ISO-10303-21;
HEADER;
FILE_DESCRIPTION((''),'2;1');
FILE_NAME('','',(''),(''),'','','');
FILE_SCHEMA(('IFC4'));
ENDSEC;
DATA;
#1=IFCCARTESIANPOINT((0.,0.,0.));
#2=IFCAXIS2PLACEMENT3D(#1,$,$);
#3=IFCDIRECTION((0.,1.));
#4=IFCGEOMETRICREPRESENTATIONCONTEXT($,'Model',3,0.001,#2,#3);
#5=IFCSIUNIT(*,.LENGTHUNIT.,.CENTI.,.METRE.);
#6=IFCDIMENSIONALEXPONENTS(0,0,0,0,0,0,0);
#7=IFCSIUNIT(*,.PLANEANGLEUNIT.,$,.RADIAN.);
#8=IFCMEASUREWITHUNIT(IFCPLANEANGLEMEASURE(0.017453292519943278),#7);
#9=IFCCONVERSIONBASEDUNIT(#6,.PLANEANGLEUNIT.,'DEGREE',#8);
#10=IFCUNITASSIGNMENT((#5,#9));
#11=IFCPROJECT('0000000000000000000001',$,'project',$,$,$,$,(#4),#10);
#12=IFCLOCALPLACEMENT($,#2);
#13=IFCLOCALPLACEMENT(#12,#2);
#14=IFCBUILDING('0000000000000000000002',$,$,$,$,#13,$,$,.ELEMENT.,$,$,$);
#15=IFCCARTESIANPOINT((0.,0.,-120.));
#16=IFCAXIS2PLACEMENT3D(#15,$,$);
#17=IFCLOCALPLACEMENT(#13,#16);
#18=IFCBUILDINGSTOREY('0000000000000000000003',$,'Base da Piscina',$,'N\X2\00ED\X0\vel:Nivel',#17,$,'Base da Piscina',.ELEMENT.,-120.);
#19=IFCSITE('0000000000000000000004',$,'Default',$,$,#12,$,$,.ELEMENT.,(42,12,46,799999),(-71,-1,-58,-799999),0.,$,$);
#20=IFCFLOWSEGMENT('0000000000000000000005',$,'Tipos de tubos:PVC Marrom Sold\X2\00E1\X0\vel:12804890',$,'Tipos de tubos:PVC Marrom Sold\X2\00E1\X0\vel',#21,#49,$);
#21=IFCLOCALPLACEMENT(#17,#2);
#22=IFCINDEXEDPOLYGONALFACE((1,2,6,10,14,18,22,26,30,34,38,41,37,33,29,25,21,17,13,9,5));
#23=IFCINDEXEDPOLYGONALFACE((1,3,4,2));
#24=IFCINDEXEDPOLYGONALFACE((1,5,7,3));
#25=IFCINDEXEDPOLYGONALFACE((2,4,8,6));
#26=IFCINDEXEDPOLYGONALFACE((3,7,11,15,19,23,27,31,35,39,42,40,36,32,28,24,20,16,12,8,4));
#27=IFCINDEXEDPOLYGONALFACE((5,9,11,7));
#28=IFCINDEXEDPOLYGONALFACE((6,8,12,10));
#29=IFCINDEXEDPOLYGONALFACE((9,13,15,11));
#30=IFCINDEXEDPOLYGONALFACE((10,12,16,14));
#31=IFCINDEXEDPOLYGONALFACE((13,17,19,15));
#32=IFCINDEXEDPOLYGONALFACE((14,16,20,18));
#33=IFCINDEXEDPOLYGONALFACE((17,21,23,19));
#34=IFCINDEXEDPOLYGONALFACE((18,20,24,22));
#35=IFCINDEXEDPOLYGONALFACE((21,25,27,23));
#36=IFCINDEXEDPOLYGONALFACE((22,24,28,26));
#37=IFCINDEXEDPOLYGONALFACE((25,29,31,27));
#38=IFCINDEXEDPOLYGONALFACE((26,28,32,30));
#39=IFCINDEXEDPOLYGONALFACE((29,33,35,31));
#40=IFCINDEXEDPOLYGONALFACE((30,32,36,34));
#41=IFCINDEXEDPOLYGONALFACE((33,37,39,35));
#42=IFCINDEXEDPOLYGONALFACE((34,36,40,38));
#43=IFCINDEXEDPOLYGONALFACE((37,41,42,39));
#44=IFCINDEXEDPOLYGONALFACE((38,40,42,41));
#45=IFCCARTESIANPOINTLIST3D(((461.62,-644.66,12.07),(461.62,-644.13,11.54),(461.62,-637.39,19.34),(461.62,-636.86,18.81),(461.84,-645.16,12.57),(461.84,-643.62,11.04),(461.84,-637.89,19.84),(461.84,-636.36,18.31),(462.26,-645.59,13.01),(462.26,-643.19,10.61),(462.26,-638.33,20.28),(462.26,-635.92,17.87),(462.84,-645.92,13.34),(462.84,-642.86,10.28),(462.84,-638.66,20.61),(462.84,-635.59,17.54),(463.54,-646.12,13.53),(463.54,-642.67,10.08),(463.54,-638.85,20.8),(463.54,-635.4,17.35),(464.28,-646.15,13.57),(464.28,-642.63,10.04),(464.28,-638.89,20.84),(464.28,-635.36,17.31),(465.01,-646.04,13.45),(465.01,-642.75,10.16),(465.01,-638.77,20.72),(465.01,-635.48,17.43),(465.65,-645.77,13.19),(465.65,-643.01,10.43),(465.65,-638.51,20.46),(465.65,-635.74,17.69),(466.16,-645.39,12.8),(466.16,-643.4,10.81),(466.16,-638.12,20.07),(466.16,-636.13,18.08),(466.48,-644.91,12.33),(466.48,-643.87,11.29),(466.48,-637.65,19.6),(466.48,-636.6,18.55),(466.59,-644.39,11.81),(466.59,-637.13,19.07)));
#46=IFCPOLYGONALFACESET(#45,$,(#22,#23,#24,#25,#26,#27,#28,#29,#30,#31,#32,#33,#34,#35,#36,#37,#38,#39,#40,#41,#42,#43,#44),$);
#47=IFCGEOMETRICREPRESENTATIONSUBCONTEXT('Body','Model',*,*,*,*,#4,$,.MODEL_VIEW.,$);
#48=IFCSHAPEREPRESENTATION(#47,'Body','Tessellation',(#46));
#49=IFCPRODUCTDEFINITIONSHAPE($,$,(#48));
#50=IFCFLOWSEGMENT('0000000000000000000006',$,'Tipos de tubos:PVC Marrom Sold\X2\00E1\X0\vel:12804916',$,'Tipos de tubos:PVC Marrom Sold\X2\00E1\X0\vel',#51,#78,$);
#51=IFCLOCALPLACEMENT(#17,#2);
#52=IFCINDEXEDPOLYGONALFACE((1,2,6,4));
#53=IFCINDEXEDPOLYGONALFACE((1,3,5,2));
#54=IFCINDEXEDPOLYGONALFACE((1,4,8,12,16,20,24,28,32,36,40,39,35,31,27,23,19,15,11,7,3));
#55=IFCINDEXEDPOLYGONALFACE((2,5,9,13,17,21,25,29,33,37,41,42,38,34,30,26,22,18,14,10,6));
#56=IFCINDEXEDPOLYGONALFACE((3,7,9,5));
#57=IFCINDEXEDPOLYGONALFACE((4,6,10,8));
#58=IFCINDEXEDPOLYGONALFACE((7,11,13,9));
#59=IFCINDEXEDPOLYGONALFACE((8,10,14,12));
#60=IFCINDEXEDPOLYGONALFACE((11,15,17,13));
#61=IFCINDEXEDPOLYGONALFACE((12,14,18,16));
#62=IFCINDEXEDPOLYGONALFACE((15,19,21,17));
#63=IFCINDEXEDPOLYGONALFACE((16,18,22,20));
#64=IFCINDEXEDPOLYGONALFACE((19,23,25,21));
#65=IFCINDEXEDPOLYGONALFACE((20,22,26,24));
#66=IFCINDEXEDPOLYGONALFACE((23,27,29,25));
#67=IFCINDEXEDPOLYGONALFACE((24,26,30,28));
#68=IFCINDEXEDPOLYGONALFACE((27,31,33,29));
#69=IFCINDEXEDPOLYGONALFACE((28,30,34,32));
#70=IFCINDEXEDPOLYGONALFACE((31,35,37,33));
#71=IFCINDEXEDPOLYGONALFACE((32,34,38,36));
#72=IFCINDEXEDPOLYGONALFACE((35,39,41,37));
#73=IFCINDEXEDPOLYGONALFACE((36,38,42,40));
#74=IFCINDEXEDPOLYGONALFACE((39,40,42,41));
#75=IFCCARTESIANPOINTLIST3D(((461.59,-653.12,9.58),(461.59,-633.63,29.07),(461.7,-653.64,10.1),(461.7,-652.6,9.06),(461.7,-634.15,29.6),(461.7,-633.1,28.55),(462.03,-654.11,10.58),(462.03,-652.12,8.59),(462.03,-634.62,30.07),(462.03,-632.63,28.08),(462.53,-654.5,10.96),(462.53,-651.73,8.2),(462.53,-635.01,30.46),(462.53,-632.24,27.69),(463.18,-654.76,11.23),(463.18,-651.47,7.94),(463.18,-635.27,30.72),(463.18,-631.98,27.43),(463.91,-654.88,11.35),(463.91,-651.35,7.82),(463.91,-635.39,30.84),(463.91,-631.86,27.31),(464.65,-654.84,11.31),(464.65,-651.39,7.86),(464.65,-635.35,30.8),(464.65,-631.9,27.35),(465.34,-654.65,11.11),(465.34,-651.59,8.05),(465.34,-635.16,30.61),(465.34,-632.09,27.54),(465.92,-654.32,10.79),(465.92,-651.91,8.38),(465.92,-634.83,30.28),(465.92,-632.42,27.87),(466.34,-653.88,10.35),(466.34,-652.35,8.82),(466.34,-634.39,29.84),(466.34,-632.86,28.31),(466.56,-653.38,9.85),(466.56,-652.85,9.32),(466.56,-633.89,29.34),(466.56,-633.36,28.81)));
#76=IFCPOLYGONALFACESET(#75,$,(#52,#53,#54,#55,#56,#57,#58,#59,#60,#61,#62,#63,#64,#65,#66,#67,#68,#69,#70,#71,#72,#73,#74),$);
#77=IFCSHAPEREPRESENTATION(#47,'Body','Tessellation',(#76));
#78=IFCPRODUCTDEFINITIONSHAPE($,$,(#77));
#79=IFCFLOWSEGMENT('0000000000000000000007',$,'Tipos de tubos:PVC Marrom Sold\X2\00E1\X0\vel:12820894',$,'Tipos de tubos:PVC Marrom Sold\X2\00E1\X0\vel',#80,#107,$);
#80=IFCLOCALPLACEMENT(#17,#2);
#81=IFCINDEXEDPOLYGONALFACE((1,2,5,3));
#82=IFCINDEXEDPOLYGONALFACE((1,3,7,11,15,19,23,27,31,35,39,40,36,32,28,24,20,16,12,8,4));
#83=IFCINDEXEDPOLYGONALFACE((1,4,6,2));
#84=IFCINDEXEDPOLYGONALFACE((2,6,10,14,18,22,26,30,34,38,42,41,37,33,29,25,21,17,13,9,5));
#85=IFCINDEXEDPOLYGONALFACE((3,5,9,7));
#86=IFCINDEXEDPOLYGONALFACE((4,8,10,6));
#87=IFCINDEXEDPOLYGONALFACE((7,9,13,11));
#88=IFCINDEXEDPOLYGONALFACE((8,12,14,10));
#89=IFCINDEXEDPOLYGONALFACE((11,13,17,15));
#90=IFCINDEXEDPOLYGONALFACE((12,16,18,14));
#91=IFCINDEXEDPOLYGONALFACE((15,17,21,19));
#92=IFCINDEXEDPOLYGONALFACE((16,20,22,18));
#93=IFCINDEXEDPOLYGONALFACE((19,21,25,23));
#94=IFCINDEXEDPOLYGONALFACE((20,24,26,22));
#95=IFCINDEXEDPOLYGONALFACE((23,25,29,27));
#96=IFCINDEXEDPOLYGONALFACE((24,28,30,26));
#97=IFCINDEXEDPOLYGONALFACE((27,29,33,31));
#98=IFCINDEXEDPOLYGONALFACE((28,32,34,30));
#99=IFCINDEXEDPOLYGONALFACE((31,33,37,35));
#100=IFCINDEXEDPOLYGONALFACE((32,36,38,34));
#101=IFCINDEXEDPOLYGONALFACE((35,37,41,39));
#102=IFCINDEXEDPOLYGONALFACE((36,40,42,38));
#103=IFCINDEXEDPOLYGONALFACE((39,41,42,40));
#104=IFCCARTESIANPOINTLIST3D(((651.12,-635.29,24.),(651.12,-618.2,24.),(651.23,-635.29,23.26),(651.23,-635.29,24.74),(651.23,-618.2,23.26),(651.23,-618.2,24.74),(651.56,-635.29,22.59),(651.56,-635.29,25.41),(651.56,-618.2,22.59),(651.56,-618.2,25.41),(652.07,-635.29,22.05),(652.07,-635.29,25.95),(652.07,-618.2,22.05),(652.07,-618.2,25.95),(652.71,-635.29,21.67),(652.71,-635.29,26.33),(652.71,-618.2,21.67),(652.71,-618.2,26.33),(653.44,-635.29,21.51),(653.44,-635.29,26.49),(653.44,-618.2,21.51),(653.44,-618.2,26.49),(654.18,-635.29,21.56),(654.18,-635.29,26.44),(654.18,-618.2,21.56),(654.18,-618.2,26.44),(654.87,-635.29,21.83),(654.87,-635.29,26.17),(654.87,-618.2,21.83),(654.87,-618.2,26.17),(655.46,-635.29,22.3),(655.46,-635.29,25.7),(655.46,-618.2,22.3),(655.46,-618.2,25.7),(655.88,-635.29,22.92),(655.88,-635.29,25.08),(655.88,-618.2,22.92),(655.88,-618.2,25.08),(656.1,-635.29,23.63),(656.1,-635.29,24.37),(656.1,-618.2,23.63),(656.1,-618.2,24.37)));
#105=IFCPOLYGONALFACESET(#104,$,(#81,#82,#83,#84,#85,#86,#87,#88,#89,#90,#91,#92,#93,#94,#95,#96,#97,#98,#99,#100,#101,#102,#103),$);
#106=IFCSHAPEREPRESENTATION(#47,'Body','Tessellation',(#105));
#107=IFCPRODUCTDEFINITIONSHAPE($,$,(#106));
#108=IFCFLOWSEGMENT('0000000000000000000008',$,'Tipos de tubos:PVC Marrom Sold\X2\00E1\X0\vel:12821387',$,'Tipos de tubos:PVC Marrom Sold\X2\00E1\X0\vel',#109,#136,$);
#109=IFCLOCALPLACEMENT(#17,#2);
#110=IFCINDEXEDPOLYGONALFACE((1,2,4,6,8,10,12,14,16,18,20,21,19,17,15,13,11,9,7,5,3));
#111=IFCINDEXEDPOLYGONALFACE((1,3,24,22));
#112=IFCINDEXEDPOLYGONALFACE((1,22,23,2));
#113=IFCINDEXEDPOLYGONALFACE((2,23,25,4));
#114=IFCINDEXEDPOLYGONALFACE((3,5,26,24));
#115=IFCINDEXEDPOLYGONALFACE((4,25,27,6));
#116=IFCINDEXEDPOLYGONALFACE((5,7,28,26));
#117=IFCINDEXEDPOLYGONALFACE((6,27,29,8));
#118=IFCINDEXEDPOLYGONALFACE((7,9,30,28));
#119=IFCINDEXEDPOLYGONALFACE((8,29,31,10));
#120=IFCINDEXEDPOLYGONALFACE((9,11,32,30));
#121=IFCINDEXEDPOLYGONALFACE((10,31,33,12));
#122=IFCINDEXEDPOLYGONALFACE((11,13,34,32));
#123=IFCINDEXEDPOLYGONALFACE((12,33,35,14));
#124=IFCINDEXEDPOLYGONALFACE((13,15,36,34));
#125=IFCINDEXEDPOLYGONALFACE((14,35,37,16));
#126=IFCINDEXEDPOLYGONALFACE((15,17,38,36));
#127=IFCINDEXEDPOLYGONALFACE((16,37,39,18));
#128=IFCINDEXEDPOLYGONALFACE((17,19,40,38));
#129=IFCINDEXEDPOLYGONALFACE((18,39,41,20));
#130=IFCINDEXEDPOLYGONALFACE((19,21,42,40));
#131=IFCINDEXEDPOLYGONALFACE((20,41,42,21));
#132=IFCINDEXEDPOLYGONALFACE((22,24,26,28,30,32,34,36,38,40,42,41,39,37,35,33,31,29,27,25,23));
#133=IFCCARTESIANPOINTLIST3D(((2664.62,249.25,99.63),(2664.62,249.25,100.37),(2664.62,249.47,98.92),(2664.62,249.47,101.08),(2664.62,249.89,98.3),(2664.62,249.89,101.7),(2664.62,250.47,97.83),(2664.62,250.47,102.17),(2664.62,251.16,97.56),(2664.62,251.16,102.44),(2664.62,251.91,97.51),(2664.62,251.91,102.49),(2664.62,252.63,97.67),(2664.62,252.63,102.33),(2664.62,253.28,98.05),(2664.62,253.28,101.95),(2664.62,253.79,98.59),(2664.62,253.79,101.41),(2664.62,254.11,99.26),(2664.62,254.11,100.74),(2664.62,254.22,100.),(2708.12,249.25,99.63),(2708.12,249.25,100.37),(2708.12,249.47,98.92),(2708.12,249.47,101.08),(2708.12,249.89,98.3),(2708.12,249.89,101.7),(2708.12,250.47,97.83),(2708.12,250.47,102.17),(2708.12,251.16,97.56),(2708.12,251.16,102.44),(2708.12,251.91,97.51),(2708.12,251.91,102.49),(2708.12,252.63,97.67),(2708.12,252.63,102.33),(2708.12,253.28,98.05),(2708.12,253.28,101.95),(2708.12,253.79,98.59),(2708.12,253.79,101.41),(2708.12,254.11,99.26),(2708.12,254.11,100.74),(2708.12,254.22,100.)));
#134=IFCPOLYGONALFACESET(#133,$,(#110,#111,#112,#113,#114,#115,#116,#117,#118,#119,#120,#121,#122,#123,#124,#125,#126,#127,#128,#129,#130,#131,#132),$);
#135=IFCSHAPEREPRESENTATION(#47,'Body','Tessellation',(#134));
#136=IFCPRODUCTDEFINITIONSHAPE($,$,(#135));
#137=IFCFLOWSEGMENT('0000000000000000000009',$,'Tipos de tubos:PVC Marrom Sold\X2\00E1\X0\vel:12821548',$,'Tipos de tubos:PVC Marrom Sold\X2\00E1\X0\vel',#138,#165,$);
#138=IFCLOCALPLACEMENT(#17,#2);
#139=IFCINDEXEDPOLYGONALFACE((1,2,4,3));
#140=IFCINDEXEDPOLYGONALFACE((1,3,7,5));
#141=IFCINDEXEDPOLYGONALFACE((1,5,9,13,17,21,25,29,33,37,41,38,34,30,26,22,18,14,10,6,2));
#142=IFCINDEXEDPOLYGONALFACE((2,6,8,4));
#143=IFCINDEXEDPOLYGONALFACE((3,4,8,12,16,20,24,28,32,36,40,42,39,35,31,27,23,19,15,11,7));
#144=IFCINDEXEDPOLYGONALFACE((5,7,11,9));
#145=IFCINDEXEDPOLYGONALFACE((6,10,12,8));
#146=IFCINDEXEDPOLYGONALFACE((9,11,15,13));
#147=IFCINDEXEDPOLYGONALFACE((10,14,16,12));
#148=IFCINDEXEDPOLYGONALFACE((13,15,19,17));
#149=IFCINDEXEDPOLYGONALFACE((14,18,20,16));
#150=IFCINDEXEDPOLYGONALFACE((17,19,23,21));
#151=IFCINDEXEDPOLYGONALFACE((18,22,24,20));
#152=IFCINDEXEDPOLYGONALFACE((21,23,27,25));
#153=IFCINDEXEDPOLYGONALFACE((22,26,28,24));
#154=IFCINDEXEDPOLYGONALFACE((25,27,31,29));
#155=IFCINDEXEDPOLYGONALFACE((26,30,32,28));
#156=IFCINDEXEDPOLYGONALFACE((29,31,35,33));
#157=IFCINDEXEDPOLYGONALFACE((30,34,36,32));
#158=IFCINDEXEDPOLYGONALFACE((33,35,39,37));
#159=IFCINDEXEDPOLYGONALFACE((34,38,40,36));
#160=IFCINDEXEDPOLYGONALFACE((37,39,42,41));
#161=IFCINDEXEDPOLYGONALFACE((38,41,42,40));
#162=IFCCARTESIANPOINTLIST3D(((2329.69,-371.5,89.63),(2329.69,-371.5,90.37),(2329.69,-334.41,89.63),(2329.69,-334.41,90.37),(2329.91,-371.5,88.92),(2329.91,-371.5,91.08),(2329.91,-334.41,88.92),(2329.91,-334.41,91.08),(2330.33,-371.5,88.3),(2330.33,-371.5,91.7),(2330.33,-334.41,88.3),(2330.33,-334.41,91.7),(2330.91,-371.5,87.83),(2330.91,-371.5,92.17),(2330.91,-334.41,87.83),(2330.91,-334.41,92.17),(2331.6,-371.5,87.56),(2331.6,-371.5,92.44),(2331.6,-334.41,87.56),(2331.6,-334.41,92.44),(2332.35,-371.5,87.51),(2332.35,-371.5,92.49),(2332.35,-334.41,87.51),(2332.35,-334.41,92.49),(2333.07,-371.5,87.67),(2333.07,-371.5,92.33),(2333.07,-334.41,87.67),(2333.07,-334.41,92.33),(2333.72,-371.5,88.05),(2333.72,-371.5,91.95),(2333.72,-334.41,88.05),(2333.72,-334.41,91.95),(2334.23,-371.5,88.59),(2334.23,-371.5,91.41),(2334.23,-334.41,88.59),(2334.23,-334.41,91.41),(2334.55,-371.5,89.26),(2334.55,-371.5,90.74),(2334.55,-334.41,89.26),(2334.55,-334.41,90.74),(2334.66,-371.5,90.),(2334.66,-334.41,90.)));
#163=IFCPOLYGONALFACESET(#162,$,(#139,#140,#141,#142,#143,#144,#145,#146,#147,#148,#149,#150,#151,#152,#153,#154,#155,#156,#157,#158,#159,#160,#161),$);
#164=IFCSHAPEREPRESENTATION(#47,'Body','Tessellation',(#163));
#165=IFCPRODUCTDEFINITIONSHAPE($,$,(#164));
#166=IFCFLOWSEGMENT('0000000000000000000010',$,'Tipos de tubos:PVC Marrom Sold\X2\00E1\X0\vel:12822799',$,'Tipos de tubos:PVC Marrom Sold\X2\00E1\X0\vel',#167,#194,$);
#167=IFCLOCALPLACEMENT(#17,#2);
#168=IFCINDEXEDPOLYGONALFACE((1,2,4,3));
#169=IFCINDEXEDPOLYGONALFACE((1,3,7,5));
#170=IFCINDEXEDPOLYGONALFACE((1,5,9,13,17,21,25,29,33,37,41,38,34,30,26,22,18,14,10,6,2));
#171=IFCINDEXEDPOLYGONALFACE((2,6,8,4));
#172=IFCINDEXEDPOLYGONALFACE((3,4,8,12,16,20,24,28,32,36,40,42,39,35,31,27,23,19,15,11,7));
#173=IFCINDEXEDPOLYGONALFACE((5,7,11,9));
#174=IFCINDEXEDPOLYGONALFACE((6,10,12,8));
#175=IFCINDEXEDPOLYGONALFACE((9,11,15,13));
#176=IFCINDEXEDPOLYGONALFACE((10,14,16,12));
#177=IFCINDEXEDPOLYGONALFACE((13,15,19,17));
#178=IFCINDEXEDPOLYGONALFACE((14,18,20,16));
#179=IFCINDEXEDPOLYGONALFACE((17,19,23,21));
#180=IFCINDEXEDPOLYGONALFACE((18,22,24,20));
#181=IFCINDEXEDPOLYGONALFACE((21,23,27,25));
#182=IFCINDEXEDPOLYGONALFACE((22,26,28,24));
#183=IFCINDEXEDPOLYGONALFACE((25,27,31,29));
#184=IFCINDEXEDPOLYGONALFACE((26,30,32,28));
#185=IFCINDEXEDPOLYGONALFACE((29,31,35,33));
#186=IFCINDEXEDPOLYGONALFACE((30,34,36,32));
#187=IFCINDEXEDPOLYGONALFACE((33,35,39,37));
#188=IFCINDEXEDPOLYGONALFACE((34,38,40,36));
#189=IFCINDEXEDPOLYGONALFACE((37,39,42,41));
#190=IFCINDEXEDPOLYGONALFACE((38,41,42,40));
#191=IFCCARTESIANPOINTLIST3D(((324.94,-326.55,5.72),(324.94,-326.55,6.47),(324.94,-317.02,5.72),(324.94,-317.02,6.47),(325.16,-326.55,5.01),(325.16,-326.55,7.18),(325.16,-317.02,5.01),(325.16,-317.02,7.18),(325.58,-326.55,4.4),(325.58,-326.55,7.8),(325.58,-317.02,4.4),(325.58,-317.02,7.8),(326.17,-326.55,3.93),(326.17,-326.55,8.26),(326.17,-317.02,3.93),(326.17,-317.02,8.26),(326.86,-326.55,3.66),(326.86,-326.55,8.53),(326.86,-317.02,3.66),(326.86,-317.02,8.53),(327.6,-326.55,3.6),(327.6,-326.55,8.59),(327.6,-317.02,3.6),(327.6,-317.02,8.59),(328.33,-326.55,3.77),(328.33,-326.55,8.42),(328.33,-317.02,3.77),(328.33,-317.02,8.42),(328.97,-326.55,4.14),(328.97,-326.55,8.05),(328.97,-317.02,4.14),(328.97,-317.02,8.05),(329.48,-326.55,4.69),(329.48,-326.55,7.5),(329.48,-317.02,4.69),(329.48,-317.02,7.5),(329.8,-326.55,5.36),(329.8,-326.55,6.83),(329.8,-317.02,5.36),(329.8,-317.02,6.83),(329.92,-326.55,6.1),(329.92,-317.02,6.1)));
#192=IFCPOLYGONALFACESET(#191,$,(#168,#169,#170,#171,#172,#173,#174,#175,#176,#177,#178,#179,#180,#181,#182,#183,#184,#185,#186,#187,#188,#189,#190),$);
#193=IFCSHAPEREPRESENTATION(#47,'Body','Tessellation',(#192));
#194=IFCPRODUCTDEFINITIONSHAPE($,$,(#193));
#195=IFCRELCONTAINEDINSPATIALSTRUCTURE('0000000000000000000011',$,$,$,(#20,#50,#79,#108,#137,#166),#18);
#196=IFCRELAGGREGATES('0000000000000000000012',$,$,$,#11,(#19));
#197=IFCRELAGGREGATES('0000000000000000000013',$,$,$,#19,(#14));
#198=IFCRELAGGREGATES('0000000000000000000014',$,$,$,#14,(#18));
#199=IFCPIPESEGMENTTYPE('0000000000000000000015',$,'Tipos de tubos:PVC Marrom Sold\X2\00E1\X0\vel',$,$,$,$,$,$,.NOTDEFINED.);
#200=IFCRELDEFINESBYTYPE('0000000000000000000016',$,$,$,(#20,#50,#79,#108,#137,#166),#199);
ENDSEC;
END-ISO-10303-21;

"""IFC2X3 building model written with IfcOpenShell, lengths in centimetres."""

from ifc_helpers import new_model, entity, si_unit, converted_unit, direction, frame, frame_2d, origin, origin_2d_with_axis, place, context, subcontext, project, spatial, circle, extrude, type_object, element, save


model = new_model("IFC2X3")

# Units and contexts
model_context = context("Model", 3, precision=0.001, world=origin(), true_north=direction((0.0, 1.0)))
body_context = subcontext(model_context, "Body", "Model", "MODEL_VIEW")
ifc_project = project(units=[si_unit("LENGTHUNIT", "METRE", prefix="CENTI"), converted_unit("PLANEANGLEUNIT", "DEGREE", entity("IfcPlaneAngleMeasure", 0.017453292519943278), si_unit("PLANEANGLEUNIT", "RADIAN"), dimensions=[0, 0, 0, 0, 0, 0, 0])], contexts=[model_context])

# Site, building, storey
site_placement = place(None, origin())
site = spatial("IfcSite", under=ifc_project, at=site_placement, Name="Default", CompositionType="ELEMENT", RefLatitude=(42, 12, 46, 799999), RefLongitude=(-71, -1, -58, -799999), RefElevation=0.0)
building_placement = place(site_placement, origin())
building = spatial("IfcBuilding", under=site, at=building_placement, CompositionType="ELEMENT")
storey_placement = place(building_placement, frame((0.0, 0.0, -120.0)))
storey = spatial("IfcBuildingStorey", under=building, at=storey_placement, Name="Base da Piscina", ObjectType="Nível:Nivel", LongName="Base da Piscina", CompositionType="ELEMENT", Elevation=-120.0)

# Flow segments
pipe_segment_type = type_object("IfcPipeSegmentType", Name="Tipos de tubos:PVC Marrom Soldável", PredefinedType="NOTDEFINED")
flow_segment_1_placement = place(storey_placement, origin())
element("IfcFlowSegment", 1, at=flow_segment_1_placement, inside=storey, type_object=pipe_segment_type, Name="Tipos de tubos:PVC Marrom Soldável:12804890", ObjectType="Tipos de tubos:PVC Marrom Soldável", context=body_context, shape_type="SweptSolid", body=[
    extrude(circle(Radius=2.5, at=frame_2d((0.0, 0.0), x_axis=(1.0, 0.0))), frame((464.09, -644.39, 11.81), z_axis=(0.0, 0.707107, 0.707107), x_axis=(1.0, 0.0, 0.0)), (0.0, 0.0, 1.0), 10.28),
])
flow_segment_2_placement = place(storey_placement, origin())
element("IfcFlowSegment", 2, at=flow_segment_2_placement, inside=storey, type_object=pipe_segment_type, Name="Tipos de tubos:PVC Marrom Soldável:12804916", ObjectType="Tipos de tubos:PVC Marrom Soldável", context=body_context, shape_type="SweptSolid", body=[
    extrude(circle(Radius=2.5, at=origin_2d_with_axis()), frame((464.09, -653.12, 9.58), z_axis=(0.0, 0.707107, 0.707107), x_axis=(-1.0, 0.0, 0.0)), (0.0, 0.0, 1.0), 27.57),
])
flow_segment_3_placement = place(storey_placement, origin())
element("IfcFlowSegment", 3, at=flow_segment_3_placement, inside=storey, type_object=pipe_segment_type, Name="Tipos de tubos:PVC Marrom Soldável:12820894", ObjectType="Tipos de tubos:PVC Marrom Soldável", context=body_context, shape_type="SweptSolid", body=[
    extrude(circle(Radius=2.5, at=origin_2d_with_axis()), frame((653.62, -635.29, 24.0), z_axis=(0.0, 1.0, 0.0), x_axis=(-1.0, 0.0, 0.0)), (0.0, 0.0, 1.0), 17.09),
])
flow_segment_4_placement = place(storey_placement, origin())
element("IfcFlowSegment", 4, at=flow_segment_4_placement, inside=storey, type_object=pipe_segment_type, Name="Tipos de tubos:PVC Marrom Soldável:12821387", ObjectType="Tipos de tubos:PVC Marrom Soldável", context=body_context, shape_type="SweptSolid", body=[
    extrude(circle(Radius=2.5, at=origin_2d_with_axis()), frame((2664.62, 251.72, 100.0), z_axis=(1.0, 0.0, 0.0), x_axis=(0.0, 1.0, 0.0)), (0.0, 0.0, 1.0), 43.51),
])
flow_segment_5_placement = place(storey_placement, origin())
element("IfcFlowSegment", 5, at=flow_segment_5_placement, inside=storey, type_object=pipe_segment_type, Name="Tipos de tubos:PVC Marrom Soldável:12821548", ObjectType="Tipos de tubos:PVC Marrom Soldável", context=body_context, shape_type="SweptSolid", body=[
    extrude(circle(Radius=2.5, at=frame_2d((0.0, 0.0), x_axis=(1.0, 0.0))), frame((2332.16, -371.5, 90.0), z_axis=(0.0, 1.0, 0.0), x_axis=(1.0, 0.0, 0.0)), (0.0, 0.0, 1.0), 37.09),
])
flow_segment_6_placement = place(storey_placement, origin())
element("IfcFlowSegment", 6, at=flow_segment_6_placement, inside=storey, type_object=pipe_segment_type, Name="Tipos de tubos:PVC Marrom Soldável:12822799", ObjectType="Tipos de tubos:PVC Marrom Soldável", context=body_context, shape_type="SweptSolid", body=[
    extrude(circle(Radius=2.5, at=origin_2d_with_axis()), frame((327.42, -326.55, 6.1), z_axis=(0.0, 1.0, 0.0), x_axis=(1.0, 0.0, 0.0)), (0.0, 0.0, 1.0), 9.53),
])

save(model, "model.ifc")
